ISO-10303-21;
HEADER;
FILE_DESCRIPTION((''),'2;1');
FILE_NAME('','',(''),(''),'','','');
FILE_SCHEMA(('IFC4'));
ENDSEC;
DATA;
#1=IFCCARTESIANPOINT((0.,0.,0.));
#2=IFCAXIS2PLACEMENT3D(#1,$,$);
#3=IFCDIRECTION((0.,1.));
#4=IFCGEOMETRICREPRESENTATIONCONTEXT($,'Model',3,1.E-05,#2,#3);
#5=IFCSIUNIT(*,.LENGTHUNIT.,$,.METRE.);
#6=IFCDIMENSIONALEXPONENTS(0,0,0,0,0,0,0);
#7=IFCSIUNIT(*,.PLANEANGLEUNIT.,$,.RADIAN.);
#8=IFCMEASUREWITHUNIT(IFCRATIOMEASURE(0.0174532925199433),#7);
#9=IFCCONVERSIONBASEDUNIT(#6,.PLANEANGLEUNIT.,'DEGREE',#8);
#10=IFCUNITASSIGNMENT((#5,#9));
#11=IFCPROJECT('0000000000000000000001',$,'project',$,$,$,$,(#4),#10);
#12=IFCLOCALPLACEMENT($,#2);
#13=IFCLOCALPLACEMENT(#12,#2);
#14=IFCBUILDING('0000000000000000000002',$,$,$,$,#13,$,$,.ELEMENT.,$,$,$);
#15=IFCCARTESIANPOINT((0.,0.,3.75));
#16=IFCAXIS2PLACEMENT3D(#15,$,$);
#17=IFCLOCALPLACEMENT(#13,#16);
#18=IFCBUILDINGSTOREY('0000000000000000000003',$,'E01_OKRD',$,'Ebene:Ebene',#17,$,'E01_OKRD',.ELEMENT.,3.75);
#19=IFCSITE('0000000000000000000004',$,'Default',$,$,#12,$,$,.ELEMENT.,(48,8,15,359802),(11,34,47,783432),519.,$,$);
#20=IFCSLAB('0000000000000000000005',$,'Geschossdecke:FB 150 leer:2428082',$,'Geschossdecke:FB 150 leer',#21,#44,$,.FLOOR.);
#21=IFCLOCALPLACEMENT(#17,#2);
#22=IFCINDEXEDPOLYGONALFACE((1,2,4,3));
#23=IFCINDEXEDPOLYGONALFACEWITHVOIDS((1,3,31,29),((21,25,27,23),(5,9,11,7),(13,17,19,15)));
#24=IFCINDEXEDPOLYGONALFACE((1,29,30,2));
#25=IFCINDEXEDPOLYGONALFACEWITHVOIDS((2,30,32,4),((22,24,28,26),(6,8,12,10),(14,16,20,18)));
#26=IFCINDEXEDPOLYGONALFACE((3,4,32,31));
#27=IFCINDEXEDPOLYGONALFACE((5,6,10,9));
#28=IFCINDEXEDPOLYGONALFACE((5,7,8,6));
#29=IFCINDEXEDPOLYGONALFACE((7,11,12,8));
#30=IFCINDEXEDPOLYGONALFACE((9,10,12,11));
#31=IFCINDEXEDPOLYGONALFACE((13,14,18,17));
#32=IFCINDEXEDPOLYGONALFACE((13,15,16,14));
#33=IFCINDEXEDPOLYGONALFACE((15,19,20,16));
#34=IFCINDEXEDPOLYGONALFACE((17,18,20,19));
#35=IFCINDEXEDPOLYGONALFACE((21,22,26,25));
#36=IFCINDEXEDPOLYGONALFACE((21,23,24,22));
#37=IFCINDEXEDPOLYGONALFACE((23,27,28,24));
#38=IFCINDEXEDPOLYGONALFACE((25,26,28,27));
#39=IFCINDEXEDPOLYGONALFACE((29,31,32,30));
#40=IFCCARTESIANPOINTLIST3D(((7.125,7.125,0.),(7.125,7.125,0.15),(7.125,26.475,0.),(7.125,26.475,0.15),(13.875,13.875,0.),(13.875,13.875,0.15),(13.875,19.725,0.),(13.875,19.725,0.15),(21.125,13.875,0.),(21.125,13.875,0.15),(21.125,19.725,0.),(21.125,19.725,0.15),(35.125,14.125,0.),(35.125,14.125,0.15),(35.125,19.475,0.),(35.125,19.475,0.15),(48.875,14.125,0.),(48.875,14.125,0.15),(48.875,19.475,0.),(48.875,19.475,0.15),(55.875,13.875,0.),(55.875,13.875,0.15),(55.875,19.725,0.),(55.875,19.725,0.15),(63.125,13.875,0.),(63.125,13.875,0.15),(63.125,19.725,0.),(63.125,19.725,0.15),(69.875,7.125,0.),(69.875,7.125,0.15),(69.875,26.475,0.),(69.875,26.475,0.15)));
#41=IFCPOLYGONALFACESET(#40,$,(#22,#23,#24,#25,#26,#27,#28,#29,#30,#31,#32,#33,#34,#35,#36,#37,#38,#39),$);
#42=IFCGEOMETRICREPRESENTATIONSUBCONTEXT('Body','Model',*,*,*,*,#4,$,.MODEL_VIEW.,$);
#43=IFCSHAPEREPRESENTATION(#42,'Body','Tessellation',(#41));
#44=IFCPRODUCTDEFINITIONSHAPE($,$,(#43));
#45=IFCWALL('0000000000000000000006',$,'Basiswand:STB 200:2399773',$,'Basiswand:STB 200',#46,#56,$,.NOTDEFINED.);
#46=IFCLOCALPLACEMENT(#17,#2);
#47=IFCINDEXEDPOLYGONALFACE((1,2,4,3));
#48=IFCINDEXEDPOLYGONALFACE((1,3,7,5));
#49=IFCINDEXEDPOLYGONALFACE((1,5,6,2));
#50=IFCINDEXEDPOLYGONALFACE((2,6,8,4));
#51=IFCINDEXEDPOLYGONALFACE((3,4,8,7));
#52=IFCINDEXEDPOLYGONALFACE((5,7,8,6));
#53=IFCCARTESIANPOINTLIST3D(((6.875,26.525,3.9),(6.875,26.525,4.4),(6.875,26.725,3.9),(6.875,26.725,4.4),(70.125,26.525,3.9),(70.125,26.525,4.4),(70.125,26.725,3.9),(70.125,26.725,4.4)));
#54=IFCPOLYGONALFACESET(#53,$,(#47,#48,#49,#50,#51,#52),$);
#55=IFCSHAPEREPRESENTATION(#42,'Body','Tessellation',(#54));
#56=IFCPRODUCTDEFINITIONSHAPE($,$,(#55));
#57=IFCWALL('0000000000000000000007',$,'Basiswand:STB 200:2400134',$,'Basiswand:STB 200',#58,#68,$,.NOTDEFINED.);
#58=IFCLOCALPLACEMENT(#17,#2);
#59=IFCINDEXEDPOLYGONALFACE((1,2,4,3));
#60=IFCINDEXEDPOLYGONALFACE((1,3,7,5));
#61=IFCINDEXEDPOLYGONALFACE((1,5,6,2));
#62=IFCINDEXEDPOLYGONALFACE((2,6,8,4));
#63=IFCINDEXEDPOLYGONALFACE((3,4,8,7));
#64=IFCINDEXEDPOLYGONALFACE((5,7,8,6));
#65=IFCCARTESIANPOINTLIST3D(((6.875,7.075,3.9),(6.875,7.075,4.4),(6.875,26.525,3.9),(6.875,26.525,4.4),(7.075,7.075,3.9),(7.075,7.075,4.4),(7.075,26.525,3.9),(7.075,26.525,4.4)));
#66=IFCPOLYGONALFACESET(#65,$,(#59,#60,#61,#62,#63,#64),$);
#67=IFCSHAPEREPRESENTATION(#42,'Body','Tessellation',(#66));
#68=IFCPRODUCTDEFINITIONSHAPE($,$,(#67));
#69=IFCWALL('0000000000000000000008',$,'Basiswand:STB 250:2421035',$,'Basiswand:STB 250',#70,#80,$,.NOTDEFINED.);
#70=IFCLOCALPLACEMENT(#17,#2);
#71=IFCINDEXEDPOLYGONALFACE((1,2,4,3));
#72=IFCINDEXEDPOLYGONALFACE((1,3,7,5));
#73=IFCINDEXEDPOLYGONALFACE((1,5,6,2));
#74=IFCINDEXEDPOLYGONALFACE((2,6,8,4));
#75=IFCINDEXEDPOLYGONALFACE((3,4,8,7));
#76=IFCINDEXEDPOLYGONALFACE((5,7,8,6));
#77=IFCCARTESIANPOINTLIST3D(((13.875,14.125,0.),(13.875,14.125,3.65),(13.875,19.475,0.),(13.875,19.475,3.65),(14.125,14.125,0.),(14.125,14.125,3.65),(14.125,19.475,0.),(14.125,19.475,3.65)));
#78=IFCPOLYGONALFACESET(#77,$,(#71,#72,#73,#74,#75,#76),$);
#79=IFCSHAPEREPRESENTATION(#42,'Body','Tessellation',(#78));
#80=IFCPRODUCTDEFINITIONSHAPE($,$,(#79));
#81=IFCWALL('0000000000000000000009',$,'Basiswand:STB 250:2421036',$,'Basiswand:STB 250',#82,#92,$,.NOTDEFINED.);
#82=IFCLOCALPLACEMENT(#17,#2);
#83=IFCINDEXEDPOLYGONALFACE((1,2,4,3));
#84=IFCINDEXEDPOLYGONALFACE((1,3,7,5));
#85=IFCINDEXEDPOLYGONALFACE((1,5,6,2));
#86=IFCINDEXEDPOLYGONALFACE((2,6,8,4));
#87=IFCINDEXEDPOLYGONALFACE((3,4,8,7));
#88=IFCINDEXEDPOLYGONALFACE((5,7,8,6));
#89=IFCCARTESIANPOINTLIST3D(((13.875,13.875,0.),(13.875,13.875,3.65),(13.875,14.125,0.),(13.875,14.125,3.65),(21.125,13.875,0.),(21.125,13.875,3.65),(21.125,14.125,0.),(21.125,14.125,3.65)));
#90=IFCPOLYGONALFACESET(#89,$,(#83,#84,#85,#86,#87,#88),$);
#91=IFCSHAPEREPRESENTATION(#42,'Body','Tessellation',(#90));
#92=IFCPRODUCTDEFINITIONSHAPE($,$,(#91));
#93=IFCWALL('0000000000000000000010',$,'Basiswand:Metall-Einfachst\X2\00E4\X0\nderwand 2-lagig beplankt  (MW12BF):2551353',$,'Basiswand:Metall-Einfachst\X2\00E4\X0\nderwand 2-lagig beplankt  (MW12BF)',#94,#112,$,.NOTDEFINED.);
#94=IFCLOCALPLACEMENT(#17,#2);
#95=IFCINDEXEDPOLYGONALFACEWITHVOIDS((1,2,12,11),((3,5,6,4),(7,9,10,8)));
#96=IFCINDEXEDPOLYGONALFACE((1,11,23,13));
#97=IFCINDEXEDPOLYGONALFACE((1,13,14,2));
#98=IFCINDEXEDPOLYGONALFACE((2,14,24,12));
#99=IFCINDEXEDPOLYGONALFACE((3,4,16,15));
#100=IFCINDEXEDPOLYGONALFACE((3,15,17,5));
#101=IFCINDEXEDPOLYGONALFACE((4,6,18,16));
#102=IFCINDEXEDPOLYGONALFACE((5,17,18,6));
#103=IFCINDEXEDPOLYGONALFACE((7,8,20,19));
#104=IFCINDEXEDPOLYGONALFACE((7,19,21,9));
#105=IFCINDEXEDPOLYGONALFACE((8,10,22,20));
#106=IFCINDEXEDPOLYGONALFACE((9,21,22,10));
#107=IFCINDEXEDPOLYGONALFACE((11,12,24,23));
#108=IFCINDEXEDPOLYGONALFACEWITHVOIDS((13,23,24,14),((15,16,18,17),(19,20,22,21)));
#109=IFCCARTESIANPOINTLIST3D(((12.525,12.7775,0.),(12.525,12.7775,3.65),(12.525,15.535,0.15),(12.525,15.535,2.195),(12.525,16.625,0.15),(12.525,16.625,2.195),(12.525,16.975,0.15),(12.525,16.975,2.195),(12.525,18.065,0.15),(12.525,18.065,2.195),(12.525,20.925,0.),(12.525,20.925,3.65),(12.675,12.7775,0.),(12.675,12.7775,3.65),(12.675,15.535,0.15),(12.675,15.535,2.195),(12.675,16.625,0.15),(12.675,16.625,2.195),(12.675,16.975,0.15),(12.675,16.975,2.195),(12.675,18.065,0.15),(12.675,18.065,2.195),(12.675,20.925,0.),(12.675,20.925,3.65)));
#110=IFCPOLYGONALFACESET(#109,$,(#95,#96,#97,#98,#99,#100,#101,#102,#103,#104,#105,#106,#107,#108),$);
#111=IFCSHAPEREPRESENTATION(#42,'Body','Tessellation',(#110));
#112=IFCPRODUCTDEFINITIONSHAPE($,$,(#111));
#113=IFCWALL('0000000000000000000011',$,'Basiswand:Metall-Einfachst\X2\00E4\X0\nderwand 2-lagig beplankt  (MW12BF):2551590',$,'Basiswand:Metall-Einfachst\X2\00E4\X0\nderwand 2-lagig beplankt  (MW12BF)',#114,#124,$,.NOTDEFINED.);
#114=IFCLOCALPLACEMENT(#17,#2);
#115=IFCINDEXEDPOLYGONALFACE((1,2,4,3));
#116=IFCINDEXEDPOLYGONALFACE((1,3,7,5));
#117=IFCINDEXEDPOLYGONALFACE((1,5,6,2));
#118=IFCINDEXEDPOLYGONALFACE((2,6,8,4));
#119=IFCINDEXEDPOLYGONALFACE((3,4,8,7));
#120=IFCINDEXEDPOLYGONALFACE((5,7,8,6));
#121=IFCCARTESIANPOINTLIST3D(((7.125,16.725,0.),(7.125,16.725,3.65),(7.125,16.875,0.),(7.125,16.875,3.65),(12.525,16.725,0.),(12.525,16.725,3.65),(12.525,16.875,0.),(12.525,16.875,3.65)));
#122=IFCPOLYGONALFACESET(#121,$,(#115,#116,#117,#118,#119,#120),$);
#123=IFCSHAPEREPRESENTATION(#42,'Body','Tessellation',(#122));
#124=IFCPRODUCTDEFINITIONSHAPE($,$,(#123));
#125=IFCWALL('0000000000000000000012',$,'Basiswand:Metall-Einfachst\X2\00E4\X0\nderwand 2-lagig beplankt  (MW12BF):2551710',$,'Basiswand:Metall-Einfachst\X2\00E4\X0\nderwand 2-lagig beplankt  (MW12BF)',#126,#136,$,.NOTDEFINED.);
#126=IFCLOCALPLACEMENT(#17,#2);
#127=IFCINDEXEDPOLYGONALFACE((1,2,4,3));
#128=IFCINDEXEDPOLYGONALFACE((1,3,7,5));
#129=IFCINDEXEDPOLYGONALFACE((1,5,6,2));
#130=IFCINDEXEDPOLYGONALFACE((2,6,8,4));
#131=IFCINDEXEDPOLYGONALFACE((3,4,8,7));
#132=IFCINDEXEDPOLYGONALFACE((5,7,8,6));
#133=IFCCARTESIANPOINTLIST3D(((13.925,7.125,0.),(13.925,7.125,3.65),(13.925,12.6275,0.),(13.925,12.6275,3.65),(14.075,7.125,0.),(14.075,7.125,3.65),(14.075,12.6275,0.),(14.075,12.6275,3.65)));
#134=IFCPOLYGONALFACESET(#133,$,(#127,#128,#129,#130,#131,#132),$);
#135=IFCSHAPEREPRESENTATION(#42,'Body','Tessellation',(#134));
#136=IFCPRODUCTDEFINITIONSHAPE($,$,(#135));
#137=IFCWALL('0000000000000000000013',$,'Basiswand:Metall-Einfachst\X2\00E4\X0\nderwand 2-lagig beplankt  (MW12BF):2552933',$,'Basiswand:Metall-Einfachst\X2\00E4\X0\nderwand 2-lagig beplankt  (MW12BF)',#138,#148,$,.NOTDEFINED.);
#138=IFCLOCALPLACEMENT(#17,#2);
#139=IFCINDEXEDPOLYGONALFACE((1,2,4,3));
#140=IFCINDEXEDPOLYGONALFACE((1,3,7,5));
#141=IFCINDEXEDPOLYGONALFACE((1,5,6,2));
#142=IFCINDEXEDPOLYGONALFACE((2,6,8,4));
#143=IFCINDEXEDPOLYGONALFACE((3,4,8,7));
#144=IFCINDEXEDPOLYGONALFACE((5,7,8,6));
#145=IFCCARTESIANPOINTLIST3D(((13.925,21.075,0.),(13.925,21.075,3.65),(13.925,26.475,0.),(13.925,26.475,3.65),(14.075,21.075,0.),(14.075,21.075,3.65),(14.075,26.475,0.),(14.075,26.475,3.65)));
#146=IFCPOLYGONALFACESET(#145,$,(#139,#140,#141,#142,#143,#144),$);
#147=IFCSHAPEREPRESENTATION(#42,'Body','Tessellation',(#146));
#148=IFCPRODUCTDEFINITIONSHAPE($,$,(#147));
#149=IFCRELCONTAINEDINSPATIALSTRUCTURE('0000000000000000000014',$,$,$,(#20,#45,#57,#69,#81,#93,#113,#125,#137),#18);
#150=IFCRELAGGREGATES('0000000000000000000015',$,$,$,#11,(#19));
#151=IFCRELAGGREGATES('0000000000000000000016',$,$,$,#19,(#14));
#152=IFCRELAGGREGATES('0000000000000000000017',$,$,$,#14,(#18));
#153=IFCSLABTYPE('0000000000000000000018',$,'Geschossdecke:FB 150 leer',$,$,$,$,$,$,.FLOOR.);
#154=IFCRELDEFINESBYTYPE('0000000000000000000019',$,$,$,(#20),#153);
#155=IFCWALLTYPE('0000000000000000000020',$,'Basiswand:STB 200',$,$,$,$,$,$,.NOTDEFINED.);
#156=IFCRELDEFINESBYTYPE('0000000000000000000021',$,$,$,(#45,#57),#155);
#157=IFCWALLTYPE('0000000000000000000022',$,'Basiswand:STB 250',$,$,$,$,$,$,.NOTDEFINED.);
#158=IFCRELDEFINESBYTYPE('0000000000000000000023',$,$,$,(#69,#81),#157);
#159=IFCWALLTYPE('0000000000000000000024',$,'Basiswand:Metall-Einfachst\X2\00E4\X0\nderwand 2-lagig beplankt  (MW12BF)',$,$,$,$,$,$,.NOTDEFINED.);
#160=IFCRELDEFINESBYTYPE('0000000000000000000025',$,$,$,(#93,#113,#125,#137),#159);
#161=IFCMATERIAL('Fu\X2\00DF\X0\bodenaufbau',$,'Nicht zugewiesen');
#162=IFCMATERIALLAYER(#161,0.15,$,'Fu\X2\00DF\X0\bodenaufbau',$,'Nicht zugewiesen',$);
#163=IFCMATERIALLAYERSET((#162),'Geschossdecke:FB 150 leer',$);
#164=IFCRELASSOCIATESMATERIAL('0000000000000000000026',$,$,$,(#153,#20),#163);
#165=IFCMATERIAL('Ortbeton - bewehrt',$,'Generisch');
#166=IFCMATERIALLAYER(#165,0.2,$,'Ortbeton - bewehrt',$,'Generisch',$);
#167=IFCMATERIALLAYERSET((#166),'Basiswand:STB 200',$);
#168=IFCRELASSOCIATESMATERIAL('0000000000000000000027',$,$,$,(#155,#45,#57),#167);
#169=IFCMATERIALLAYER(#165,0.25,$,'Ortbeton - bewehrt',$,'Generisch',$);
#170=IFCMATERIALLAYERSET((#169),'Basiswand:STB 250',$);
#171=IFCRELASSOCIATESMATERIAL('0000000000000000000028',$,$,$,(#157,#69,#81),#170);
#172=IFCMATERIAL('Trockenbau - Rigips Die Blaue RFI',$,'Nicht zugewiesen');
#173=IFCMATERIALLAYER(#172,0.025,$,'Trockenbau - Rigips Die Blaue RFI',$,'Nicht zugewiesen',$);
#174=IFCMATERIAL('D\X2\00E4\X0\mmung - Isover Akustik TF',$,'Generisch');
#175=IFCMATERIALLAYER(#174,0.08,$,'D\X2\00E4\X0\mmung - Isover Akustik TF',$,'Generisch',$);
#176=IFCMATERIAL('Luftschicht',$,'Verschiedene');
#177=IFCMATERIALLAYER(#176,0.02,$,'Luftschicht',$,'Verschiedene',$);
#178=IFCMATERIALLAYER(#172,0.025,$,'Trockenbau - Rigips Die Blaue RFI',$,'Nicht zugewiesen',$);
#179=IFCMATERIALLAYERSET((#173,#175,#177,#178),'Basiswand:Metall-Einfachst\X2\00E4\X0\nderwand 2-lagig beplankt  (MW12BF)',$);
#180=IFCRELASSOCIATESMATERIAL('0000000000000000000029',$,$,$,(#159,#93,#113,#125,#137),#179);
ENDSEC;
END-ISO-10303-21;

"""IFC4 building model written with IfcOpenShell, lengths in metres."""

from ifc_helpers import new_model, entity, si_unit, converted_unit, direction, frame, frame_2d, origin, origin_2d_with_axis, place, context, subcontext, project, spatial, rectangle, extrude, material, layer, layer_set, layer_usage, type_object, element, save


model = new_model("IFC4")

# Units and contexts
model_context = context("Model", 3, precision=1e-05, world=origin(), true_north=direction((0.0, 1.0)))
body_context = subcontext(model_context, "Body", "Model", "MODEL_VIEW")
ifc_project = project(units=[si_unit("LENGTHUNIT", "METRE"), converted_unit("PLANEANGLEUNIT", "DEGREE", entity("IfcRatioMeasure", 0.0174532925199433), si_unit("PLANEANGLEUNIT", "RADIAN"), dimensions=[0, 0, 0, 0, 0, 0, 0])], contexts=[model_context])

# Site, building, storey
site_placement = place(None, frame((0.0, 0.0, 0.0)))
site = spatial("IfcSite", under=ifc_project, at=site_placement, Name="Default", CompositionType="ELEMENT", RefLatitude=(48, 8, 15, 359802), RefLongitude=(11, 34, 47, 783432), RefElevation=519.0)
building_placement = place(site_placement, origin())
building = spatial("IfcBuilding", under=site, at=building_placement, CompositionType="ELEMENT")
storey_placement = place(building_placement, frame((0.0, 0.0, 3.75)))
storey = spatial("IfcBuildingStorey", under=building, at=storey_placement, Name="E01_OKRD", ObjectType="Ebene:Ebene", LongName="E01_OKRD", CompositionType="ELEMENT", Elevation=3.75)

# Shared definitions
ifc_material_1 = material(Name="Ortbeton - bewehrt", Category="Generisch")

# Slab, openings
ifc_material_2 = material(Name="Fußbodenaufbau", Category="Nicht zugewiesen")
ifc_layer_1 = layer(ifc_material_2, 0.15, Name="Fußbodenaufbau", Category="Nicht zugewiesen")
ifc_layer_set_1 = layer_set([ifc_layer_1], Name="Geschossdecke:FB 150 leer")
ifc_layer_usage_1 = layer_usage(ifc_layer_set_1, "AXIS3", "POSITIVE", 0.0)
slab_type_1 = type_object("IfcSlabType", Name="Geschossdecke:FB 150 leer", PredefinedType="FLOOR", material=ifc_layer_set_1)
slab_1_placement = place(storey_placement, frame((7.125, 7.125, 0.0)))
slab_1 = element("IfcSlab", 1, at=slab_1_placement, inside=storey, type_object=slab_type_1, material=ifc_layer_usage_1, Name="Geschossdecke:FB 150 leer:2428082", ObjectType="Geschossdecke:FB 150 leer", PredefinedType="FLOOR", context=body_context, shape_type="SweptSolid", body=[
    extrude(rectangle(XDim=19.35, YDim=62.75, at=frame_2d((0.0, 0.0), x_axis=(0.0, -1.0))), frame((31.375, 9.675, 0.15), z_axis=(0.0, 0.0, -1.0), x_axis=(-1.0, 0.0, 0.0)), (0.0, 0.0, 1.0), 0.15),
])
opening_1_placement = place(slab_1_placement, frame((52.375, 9.675, 0.15)))
element("IfcOpeningElement", 2, at=opening_1_placement, cuts=slab_1, ObjectType="Opening", context=body_context, shape_type="SweptSolid", body=[
    extrude(rectangle(XDim=7.25, YDim=5.85, at=origin_2d_with_axis()), frame((0.0, 0.0, 0.0), z_axis=(0.0, 0.0, -1.0), x_axis=(-1.0, 0.0, 0.0)), (0.0, 0.0, 1.0), 0.15),
])
opening_2_placement = place(slab_1_placement, frame((34.875, 9.675, 0.15)))
element("IfcOpeningElement", 3, at=opening_2_placement, cuts=slab_1, ObjectType="Opening", context=body_context, shape_type="SweptSolid", body=[
    extrude(rectangle(XDim=5.35, YDim=13.75, at=origin_2d_with_axis()), frame((0.0, 0.0, 0.0), z_axis=(0.0, 0.0, 1.0), x_axis=(0.0, 1.0, 0.0)), (0.0, 0.0, -1.0), 0.15),
])
opening_3_placement = place(slab_1_placement, frame((10.375, 9.675, 0.15)))
element("IfcOpeningElement", 4, at=opening_3_placement, cuts=slab_1, ObjectType="Opening", context=body_context, shape_type="SweptSolid", body=[
    extrude(rectangle(XDim=5.85, YDim=7.25, at=origin_2d_with_axis()), frame((0.0, 0.0, 0.0), z_axis=(0.0, 0.0, -1.0), x_axis=(0.0, 1.0, 0.0)), (0.0, 0.0, 1.0), 0.15),
])

# Walls
ifc_layer_2 = layer(ifc_material_1, 0.2, Name="Ortbeton - bewehrt", Category="Generisch")
ifc_layer_set_2 = layer_set([ifc_layer_2], Name="Basiswand:STB 200")
ifc_layer_usage_2 = layer_usage(ifc_layer_set_2, "AXIS2", "NEGATIVE", 0.1)
wall_type_1 = type_object("IfcWallType", Name="Basiswand:STB 200", PredefinedType="NOTDEFINED", material=ifc_layer_set_2)
wall_1_placement = place(storey_placement, frame((6.875, 26.625, 3.9)))
element("IfcWall", 5, at=wall_1_placement, inside=storey, type_object=wall_type_1, material=ifc_layer_usage_2, Name="Basiswand:STB 200:2399773", ObjectType="Basiswand:STB 200", PredefinedType="NOTDEFINED", context=body_context, shape_type="SweptSolid", body=[
    extrude(rectangle(XDim=63.25, YDim=0.2, at=frame_2d((31.625, 0.0), x_axis=(-1.0, 0.0))), origin(), (0.0, 0.0, 1.0), 0.5),
])
ifc_layer_usage_3 = layer_usage(ifc_layer_set_2, "AXIS2", "NEGATIVE", 0.1)
wall_2_placement = place(storey_placement, frame((6.975, 7.075, 3.9), z_axis=(0.0, 0.0, 1.0), x_axis=(0.0, 1.0, 0.0)))
element("IfcWall", 6, at=wall_2_placement, inside=storey, type_object=wall_type_1, material=ifc_layer_usage_3, Name="Basiswand:STB 200:2400134", ObjectType="Basiswand:STB 200", PredefinedType="NOTDEFINED", context=body_context, shape_type="SweptSolid", body=[
    extrude(rectangle(XDim=19.45, YDim=0.2, at=frame_2d((9.725, 0.0), x_axis=(-1.0, 0.0))), origin(), (0.0, 0.0, 1.0), 0.5),
])
ifc_layer_3 = layer(ifc_material_1, 0.25, Name="Ortbeton - bewehrt", Category="Generisch")
ifc_layer_set_3 = layer_set([ifc_layer_3], Name="Basiswand:STB 250")
ifc_layer_usage_4 = layer_usage(ifc_layer_set_3, "AXIS2", "POSITIVE", -0.125)
wall_type_2 = type_object("IfcWallType", Name="Basiswand:STB 250", PredefinedType="NOTDEFINED", material=ifc_layer_set_3)
wall_3_placement = place(storey_placement, frame((14.0, 14.125, 0.0), z_axis=(0.0, 0.0, 1.0), x_axis=(0.0, 1.0, 0.0)))
element("IfcWall", 7, at=wall_3_placement, inside=storey, type_object=wall_type_2, material=ifc_layer_usage_4, Name="Basiswand:STB 250:2421035", ObjectType="Basiswand:STB 250", PredefinedType="NOTDEFINED", context=body_context, shape_type="SweptSolid", body=[
    extrude(rectangle(XDim=5.35, YDim=0.25, at=frame_2d((2.675, 0.0), x_axis=(-1.0, 0.0))), origin(), (0.0, 0.0, 1.0), 3.65),
])
ifc_layer_usage_5 = layer_usage(ifc_layer_set_3, "AXIS2", "POSITIVE", -0.125)
wall_4_placement = place(storey_placement, frame((13.875, 14.0, 0.0)))
element("IfcWall", 8, at=wall_4_placement, inside=storey, type_object=wall_type_2, material=ifc_layer_usage_5, Name="Basiswand:STB 250:2421036", ObjectType="Basiswand:STB 250", PredefinedType="NOTDEFINED", context=body_context, shape_type="SweptSolid", body=[
    extrude(rectangle(XDim=7.25, YDim=0.25, at=frame_2d((3.625, 0.0), x_axis=(-1.0, 0.0))), origin(), (0.0, 0.0, 1.0), 3.65),
])

# Wall, openings
ifc_material_3 = material(Name="Trockenbau - Rigips Die Blaue RFI", Category="Nicht zugewiesen")
ifc_layer_4 = layer(ifc_material_3, 0.025, Name="Trockenbau - Rigips Die Blaue RFI", Category="Nicht zugewiesen")
ifc_material_4 = material(Name="Dämmung - Isover Akustik TF", Category="Generisch")
ifc_layer_5 = layer(ifc_material_4, 0.08, Name="Dämmung - Isover Akustik TF", Category="Generisch")
ifc_material_5 = material(Name="Luftschicht", Category="Verschiedene")
ifc_layer_6 = layer(ifc_material_5, 0.02, Name="Luftschicht", Category="Verschiedene")
ifc_layer_7 = layer(ifc_material_3, 0.025, Name="Trockenbau - Rigips Die Blaue RFI", Category="Nicht zugewiesen")
ifc_layer_set_4 = layer_set([ifc_layer_4, ifc_layer_5, ifc_layer_6, ifc_layer_7], Name="Basiswand:Metall-Einfachständerwand 2-lagig beplankt  (MW12BF)")
ifc_layer_usage_6 = layer_usage(ifc_layer_set_4, "AXIS2", "NEGATIVE", 0.075)
wall_type_3 = type_object("IfcWallType", Name="Basiswand:Metall-Einfachständerwand 2-lagig beplankt  (MW12BF)", PredefinedType="NOTDEFINED", material=ifc_layer_set_4)
wall_5_placement = place(storey_placement, frame((12.6, 12.7775, 0.0), z_axis=(0.0, 0.0, 1.0), x_axis=(0.0, 1.0, 0.0)))
wall_5 = element("IfcWall", 9, at=wall_5_placement, inside=storey, type_object=wall_type_3, material=ifc_layer_usage_6, Name="Basiswand:Metall-Einfachständerwand 2-lagig beplankt  (MW12BF):2551353", ObjectType="Basiswand:Metall-Einfachständerwand 2-lagig beplankt  (MW12BF)", PredefinedType="NOTDEFINED", context=body_context, shape_type="SweptSolid", body=[
    extrude(rectangle(XDim=8.1475, YDim=0.15, at=frame_2d((4.0738, 0.0), x_axis=(-1.0, 0.0))), origin(), (0.0, 0.0, 1.0), 3.65),
])
opening_4_placement = place(wall_5_placement, frame((2.7575, -0.075, 0.15)))
element("IfcOpeningElement", 10, at=opening_4_placement, cuts=wall_5, ObjectType="Opening", PredefinedType="OPENING", context=body_context, shape_type="SweptSolid", body=[
    extrude(rectangle(XDim=2.045, YDim=1.09, at=frame_2d((1.0225, 0.545), x_axis=(-1.0, 0.0))), frame((0.0, 0.0, 0.0), z_axis=(0.0, 1.0, 0.0), x_axis=(0.0, 0.0, 1.0)), (0.0, 0.0, 1.0), 0.15),
])
opening_5_placement = place(wall_5_placement, frame((4.1975, -0.075, 0.15)))
element("IfcOpeningElement", 11, at=opening_5_placement, cuts=wall_5, ObjectType="Opening", PredefinedType="OPENING", context=body_context, shape_type="SweptSolid", body=[
    extrude(rectangle(XDim=2.045, YDim=1.09, at=frame_2d((1.0225, 0.545), x_axis=(-1.0, 0.0))), frame((0.0, 0.0, 0.0), z_axis=(0.0, 1.0, 0.0), x_axis=(0.0, 0.0, 1.0)), (0.0, 0.0, 1.0), 0.15),
])

# Walls
ifc_layer_usage_7 = layer_usage(ifc_layer_set_4, "AXIS2", "NEGATIVE", 0.075)
wall_6_placement = place(storey_placement, frame((7.125, 16.8, 0.0)))
element("IfcWall", 12, at=wall_6_placement, inside=storey, type_object=wall_type_3, material=ifc_layer_usage_7, Name="Basiswand:Metall-Einfachständerwand 2-lagig beplankt  (MW12BF):2551590", ObjectType="Basiswand:Metall-Einfachständerwand 2-lagig beplankt  (MW12BF)", PredefinedType="NOTDEFINED", context=body_context, shape_type="SweptSolid", body=[
    extrude(rectangle(XDim=5.4, YDim=0.15, at=frame_2d((2.7, 0.0), x_axis=(-1.0, 0.0))), origin(), (0.0, 0.0, 1.0), 3.65),
])
ifc_layer_usage_8 = layer_usage(ifc_layer_set_4, "AXIS2", "NEGATIVE", 0.075)
wall_7_placement = place(storey_placement, frame((14.0, 7.125, 0.0), z_axis=(0.0, 0.0, 1.0), x_axis=(0.0, 1.0, 0.0)))
element("IfcWall", 13, at=wall_7_placement, inside=storey, type_object=wall_type_3, material=ifc_layer_usage_8, Name="Basiswand:Metall-Einfachständerwand 2-lagig beplankt  (MW12BF):2551710", ObjectType="Basiswand:Metall-Einfachständerwand 2-lagig beplankt  (MW12BF)", PredefinedType="NOTDEFINED", context=body_context, shape_type="SweptSolid", body=[
    extrude(rectangle(XDim=5.5025, YDim=0.15, at=frame_2d((2.7513, 0.0), x_axis=(-1.0, 0.0))), origin(), (0.0, 0.0, 1.0), 3.65),
])
ifc_layer_usage_9 = layer_usage(ifc_layer_set_4, "AXIS2", "NEGATIVE", 0.075)
wall_8_placement = place(storey_placement, frame((14.0, 21.075, 0.0), z_axis=(0.0, 0.0, 1.0), x_axis=(0.0, 1.0, 0.0)))
element("IfcWall", 14, at=wall_8_placement, inside=storey, type_object=wall_type_3, material=ifc_layer_usage_9, Name="Basiswand:Metall-Einfachständerwand 2-lagig beplankt  (MW12BF):2552933", ObjectType="Basiswand:Metall-Einfachständerwand 2-lagig beplankt  (MW12BF)", PredefinedType="NOTDEFINED", context=body_context, shape_type="SweptSolid", body=[
    extrude(rectangle(XDim=5.4, YDim=0.15, at=frame_2d((2.7, 0.0), x_axis=(-1.0, 0.0))), origin(), (0.0, 0.0, 1.0), 3.65),
])

save(model, "model.ifc")
